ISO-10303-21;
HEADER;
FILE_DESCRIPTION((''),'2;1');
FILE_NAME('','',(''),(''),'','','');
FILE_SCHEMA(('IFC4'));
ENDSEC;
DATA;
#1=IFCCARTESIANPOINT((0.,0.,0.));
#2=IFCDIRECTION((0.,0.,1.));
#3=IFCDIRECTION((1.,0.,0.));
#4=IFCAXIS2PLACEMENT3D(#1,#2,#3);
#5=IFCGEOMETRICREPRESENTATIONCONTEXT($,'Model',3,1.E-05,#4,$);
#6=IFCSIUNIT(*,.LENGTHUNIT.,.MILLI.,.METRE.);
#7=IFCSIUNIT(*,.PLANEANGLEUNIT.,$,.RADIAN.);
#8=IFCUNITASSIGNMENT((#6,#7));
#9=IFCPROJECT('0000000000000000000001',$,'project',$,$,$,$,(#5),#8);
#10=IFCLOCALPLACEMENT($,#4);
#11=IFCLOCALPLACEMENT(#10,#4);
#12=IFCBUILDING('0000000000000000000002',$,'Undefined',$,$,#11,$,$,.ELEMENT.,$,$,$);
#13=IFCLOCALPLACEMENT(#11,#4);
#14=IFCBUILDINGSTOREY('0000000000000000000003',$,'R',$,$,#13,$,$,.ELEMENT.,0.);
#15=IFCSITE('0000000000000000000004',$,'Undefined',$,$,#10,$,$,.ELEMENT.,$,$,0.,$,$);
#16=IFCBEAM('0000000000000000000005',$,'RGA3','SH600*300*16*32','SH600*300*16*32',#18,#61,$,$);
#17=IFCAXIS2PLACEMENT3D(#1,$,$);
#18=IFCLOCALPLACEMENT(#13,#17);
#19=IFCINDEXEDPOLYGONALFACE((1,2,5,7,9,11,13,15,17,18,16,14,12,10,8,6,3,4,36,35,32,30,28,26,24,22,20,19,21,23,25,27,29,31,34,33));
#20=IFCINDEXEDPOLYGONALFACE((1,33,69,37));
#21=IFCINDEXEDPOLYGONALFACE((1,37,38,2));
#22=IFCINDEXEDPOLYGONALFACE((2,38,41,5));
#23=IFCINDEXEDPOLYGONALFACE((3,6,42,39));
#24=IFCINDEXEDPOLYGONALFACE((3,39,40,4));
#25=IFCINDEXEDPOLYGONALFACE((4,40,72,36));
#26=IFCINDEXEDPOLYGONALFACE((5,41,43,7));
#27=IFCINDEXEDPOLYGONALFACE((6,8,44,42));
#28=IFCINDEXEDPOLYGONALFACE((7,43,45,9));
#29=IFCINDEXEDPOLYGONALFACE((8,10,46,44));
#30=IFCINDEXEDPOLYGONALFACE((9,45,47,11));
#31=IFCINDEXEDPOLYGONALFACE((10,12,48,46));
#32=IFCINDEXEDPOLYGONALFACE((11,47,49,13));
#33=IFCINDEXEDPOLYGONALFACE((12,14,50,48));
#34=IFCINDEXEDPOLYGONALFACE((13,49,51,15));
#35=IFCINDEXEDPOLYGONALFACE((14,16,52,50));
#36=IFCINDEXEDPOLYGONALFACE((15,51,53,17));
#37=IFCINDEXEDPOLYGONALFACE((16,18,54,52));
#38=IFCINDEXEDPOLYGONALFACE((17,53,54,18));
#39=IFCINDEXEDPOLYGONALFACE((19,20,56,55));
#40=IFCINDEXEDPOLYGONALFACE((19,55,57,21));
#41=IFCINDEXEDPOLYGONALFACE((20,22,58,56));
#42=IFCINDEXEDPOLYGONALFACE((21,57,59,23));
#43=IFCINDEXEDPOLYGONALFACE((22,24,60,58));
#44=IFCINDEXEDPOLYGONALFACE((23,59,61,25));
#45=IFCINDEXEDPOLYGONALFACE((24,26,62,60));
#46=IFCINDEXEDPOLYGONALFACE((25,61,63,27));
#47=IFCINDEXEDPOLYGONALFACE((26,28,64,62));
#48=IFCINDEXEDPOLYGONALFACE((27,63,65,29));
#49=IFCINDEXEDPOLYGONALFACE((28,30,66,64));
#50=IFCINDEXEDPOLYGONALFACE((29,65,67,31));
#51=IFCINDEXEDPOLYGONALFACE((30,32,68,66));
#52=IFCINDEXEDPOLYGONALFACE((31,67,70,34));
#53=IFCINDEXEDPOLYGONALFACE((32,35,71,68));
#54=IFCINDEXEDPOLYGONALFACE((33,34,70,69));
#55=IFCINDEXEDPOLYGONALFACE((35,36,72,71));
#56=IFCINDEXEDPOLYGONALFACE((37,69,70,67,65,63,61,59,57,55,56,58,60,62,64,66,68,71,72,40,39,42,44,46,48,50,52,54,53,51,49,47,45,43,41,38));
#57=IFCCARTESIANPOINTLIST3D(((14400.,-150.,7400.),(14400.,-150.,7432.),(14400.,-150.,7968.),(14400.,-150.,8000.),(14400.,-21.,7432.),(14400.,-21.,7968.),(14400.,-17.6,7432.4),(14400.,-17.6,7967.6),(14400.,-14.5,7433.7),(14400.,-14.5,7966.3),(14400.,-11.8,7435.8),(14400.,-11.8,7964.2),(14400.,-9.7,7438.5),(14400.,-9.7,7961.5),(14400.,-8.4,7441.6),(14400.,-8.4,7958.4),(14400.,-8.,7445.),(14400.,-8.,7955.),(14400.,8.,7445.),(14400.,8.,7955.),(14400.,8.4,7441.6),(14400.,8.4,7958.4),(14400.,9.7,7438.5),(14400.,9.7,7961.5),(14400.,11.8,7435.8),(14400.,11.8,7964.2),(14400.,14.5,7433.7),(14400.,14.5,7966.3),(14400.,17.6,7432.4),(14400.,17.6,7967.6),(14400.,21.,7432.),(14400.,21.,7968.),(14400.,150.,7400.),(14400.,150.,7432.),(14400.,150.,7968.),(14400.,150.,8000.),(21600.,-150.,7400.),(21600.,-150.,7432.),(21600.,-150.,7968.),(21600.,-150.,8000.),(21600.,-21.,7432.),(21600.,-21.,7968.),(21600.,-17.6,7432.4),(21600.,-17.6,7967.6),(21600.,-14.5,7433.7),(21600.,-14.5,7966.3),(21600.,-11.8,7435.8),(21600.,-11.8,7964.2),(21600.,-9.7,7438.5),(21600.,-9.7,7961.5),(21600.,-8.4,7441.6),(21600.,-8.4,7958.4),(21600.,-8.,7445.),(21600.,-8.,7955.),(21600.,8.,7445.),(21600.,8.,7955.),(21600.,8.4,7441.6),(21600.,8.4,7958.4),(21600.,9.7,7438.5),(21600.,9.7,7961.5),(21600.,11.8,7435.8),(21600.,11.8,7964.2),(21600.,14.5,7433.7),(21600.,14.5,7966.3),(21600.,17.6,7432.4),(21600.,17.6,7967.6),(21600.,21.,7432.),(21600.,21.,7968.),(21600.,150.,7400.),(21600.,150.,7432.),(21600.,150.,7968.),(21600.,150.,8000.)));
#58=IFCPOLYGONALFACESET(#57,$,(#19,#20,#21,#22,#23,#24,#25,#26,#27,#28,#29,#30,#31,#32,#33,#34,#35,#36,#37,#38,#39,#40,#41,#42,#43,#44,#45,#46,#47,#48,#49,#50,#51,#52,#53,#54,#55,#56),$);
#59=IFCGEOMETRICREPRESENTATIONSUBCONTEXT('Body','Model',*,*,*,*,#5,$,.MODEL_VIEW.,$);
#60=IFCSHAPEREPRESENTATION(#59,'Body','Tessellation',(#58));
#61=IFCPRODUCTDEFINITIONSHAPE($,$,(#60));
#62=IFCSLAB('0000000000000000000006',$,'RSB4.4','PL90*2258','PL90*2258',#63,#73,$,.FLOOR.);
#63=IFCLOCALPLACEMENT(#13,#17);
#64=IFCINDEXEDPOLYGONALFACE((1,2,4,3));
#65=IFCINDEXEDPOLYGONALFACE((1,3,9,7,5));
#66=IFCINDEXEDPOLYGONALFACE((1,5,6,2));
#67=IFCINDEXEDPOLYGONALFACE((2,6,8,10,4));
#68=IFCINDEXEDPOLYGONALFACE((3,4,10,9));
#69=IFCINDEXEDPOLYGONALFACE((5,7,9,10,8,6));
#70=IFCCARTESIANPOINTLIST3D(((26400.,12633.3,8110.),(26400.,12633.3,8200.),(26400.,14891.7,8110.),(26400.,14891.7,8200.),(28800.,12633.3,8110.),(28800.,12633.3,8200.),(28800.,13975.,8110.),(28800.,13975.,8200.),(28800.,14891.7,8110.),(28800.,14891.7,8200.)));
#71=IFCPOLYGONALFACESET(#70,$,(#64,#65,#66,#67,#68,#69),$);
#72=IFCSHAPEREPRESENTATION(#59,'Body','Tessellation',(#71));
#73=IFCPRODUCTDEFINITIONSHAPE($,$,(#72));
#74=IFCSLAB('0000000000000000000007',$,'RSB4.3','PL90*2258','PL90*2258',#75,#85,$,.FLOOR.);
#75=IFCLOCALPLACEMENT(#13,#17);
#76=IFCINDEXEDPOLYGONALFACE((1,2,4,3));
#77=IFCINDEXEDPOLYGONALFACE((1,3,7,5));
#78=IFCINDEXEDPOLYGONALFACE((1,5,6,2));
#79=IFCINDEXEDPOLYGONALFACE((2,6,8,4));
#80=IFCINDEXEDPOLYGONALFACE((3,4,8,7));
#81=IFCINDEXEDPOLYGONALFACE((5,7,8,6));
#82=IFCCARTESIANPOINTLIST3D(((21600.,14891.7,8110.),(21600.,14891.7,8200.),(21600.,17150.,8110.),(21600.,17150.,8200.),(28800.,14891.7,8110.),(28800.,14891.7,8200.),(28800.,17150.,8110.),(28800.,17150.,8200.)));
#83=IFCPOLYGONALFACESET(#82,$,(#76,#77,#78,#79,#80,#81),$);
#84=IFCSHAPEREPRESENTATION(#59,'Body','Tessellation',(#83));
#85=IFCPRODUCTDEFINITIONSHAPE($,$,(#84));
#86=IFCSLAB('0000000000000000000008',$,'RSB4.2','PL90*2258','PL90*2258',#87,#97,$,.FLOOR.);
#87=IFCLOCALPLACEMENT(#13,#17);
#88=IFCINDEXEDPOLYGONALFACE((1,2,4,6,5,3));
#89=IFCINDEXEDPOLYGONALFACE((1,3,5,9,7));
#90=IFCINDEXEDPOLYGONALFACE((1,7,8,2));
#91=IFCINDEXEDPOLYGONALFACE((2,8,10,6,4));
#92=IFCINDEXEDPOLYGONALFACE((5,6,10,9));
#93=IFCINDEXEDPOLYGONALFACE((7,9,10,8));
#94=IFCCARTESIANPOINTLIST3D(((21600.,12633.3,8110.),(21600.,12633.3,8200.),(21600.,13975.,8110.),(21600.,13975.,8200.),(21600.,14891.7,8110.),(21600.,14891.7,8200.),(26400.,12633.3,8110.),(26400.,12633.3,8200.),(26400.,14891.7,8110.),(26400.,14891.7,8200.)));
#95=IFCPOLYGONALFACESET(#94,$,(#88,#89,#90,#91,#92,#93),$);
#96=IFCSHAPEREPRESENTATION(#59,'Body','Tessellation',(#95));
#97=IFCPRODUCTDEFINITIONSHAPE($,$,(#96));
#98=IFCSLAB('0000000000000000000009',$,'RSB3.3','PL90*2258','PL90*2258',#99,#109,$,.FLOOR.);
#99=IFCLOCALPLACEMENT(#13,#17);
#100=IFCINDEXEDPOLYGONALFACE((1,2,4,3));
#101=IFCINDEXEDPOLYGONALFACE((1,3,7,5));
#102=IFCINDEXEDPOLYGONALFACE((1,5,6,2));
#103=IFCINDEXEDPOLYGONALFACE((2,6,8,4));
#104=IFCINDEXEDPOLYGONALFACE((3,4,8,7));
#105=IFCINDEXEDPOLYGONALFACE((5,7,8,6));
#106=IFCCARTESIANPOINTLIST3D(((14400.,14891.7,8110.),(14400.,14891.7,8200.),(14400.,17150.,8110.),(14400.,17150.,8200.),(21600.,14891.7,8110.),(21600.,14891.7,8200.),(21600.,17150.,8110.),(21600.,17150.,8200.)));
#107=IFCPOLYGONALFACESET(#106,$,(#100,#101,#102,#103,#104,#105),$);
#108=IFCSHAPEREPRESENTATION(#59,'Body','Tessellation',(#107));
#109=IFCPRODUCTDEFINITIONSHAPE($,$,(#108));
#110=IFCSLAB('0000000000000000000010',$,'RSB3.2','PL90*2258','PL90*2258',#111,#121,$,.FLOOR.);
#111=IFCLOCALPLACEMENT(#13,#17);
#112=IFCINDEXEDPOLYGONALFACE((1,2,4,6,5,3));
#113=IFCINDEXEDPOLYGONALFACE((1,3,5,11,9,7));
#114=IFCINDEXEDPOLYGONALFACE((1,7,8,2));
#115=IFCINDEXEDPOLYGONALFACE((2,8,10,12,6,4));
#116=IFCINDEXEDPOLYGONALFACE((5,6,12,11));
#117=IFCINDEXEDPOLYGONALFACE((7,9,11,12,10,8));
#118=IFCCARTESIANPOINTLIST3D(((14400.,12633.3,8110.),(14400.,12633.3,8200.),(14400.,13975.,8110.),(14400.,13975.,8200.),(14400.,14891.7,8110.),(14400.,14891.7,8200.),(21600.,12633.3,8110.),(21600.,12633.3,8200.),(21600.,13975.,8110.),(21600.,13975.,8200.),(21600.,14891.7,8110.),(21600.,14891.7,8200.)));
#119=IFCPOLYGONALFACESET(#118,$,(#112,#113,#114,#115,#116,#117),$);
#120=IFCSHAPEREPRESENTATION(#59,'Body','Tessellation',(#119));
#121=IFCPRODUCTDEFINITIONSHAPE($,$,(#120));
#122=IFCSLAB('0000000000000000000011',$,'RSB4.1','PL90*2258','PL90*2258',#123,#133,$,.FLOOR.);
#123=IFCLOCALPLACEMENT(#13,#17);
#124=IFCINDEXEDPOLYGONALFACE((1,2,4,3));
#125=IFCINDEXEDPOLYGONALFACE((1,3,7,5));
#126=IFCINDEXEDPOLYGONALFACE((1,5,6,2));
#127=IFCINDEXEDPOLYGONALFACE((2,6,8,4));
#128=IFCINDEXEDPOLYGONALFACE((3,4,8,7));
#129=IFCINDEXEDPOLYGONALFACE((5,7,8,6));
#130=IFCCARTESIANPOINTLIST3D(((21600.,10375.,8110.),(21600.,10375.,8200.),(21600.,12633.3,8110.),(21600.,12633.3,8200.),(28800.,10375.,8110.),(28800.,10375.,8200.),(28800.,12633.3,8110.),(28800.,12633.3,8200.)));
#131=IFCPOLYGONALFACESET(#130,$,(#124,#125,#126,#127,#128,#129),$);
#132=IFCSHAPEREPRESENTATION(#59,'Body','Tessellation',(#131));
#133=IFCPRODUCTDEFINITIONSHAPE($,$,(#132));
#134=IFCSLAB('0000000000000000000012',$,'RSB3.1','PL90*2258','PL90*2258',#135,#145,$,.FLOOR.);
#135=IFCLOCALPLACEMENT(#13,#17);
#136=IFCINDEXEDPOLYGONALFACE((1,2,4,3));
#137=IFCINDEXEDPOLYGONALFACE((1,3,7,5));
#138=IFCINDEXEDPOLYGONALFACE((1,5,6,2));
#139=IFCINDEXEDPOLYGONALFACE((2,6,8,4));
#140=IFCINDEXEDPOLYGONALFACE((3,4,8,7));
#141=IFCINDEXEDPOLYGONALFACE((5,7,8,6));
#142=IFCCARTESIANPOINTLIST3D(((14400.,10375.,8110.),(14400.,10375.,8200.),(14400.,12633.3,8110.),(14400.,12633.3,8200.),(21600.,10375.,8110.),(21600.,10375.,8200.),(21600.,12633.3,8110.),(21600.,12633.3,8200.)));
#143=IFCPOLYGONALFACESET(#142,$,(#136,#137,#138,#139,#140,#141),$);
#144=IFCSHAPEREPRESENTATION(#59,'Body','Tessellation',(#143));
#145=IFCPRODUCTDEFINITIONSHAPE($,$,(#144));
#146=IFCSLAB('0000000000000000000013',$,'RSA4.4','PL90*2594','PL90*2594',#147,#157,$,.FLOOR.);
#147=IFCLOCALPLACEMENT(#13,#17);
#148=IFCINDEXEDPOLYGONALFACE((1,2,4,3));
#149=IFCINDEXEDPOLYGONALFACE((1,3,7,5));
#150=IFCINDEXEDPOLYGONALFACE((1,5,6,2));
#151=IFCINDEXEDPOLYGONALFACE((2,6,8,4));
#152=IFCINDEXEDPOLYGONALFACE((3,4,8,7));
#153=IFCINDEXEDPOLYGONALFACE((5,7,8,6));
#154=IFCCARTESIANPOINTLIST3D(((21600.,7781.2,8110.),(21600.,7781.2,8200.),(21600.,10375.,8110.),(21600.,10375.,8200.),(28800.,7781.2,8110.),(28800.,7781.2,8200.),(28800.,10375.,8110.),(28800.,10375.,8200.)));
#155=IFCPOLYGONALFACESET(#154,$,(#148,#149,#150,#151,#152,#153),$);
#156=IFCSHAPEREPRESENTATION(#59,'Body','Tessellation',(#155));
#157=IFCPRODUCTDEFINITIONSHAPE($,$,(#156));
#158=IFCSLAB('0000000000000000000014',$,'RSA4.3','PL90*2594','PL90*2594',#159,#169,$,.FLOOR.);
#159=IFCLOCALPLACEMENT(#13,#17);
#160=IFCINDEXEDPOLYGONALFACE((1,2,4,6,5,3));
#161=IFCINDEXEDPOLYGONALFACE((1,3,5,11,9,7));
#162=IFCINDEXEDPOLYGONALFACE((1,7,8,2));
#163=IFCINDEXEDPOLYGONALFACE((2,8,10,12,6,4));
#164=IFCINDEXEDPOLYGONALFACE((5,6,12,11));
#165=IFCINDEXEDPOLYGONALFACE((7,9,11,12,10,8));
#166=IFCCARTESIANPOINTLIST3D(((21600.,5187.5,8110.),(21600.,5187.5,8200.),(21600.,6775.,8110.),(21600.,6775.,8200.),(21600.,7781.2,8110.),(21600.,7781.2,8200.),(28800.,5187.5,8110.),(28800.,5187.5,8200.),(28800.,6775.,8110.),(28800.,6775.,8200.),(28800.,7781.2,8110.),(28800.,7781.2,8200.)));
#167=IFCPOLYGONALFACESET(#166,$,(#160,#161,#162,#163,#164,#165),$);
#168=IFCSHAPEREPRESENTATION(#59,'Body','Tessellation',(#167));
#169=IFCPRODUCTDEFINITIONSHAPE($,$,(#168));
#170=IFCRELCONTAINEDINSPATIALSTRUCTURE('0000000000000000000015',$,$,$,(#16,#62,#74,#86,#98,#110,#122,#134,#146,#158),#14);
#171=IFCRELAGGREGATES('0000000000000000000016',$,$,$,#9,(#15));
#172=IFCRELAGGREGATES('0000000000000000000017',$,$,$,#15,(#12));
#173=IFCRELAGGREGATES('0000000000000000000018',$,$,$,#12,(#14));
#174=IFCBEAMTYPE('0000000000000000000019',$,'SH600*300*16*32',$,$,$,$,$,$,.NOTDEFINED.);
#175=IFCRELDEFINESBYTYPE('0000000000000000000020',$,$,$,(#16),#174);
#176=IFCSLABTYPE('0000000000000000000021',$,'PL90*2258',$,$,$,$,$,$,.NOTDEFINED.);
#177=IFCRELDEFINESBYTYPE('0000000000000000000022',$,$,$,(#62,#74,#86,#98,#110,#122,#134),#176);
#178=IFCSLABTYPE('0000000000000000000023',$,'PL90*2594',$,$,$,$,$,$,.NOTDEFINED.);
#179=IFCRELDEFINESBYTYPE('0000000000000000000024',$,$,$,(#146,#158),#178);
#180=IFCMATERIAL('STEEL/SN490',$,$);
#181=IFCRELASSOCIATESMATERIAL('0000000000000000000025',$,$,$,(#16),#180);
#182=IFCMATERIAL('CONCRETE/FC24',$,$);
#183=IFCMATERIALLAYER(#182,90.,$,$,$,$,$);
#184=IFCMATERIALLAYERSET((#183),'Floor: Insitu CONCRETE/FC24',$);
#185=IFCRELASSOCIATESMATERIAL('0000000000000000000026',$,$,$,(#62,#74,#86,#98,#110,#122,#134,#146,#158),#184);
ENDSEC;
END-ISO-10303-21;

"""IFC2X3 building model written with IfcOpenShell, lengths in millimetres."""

from ifc_helpers import new_model, si_unit, frame, origin_with_axes, origin_2d_with_axis, place, context, subcontext, project, spatial, polyline, i_section, outline, extrude, material, layer, layer_set, layer_usage, type_object, element, save


model = new_model("IFC2X3")

# Units and contexts
model_context = context("Model", 3, precision=1e-05, world=origin_with_axes())
body_context = subcontext(model_context, "Body", "Model", "MODEL_VIEW")
ifc_project = project(units=[si_unit("LENGTHUNIT", "METRE", prefix="MILLI"), si_unit("PLANEANGLEUNIT", "RADIAN")], contexts=[model_context])

# Site, building, storey
site_placement = place(None, origin_with_axes())
site = spatial("IfcSite", under=ifc_project, at=site_placement, Name="Undefined", CompositionType="ELEMENT", RefElevation=0.0)
building_placement = place(site_placement, origin_with_axes())
building = spatial("IfcBuilding", under=site, at=building_placement, Name="Undefined", CompositionType="ELEMENT")
storey_placement = place(building_placement, origin_with_axes())
storey = spatial("IfcBuildingStorey", under=building, at=storey_placement, Name="R", CompositionType="ELEMENT", Elevation=0.0)

# Beam
ifc_material_1 = material(Name="STEEL/SN490")
beam_type_1 = type_object("IfcBeamType", Name="SH600*300*16*32", PredefinedType="NOTDEFINED")
for number, where, z_axis, x_axis, name in (
    (1, (14400.0, 0.0, 7700.0), (0.0, 0.0, 1.0), (1.0, 0.0, 0.0), "RGA3"),
):
    element("IfcBeam", number, at=place(storey_placement, frame(where, z_axis=z_axis, x_axis=x_axis)), inside=storey, type_object=beam_type_1, material=ifc_material_1, Name=name, Description="SH600*300*16*32", ObjectType="SH600*300*16*32", context=body_context, shape_type="SweptSolid", body=[
        extrude(i_section(OverallWidth=300.0, OverallDepth=600.0, WebThickness=16.0, FlangeThickness=32.0, FilletRadius=13.0, at=origin_2d_with_axis()), frame((7200.0, 0.0, 0.0), z_axis=(-1.0, 0.0, 0.0), x_axis=(0.0, -1.0, 0.0)), (0.0, 0.0, 1.0), 7200.0),
    ])

# Slabs
ifc_material_2 = material(Name="CONCRETE/FC24")
ifc_layer = layer(ifc_material_2, 90.0)
ifc_layer_set = layer_set([ifc_layer], Name="Floor: Insitu CONCRETE/FC24")
ifc_layer_usage_1 = layer_usage(ifc_layer_set, "AXIS3", "POSITIVE", -45.0)
slab_type_1 = type_object("IfcSlabType", Name="PL90*2258", PredefinedType="NOTDEFINED")
slab_1_placement = place(storey_placement, frame((26400.0, 12633.3, 8155.0), z_axis=(0.0, 0.0, 1.0), x_axis=(1.0, 0.0, 0.0)))
element("IfcSlab", 2, at=slab_1_placement, inside=storey, type_object=slab_type_1, material=ifc_layer_usage_1, Name="RSB4.4", Description="PL90*2258", ObjectType="PL90*2258", PredefinedType="FLOOR", context=body_context, shape_type="SweptSolid", body=[
    extrude(outline(polyline([(0.0, 0.0), (2400.0, 0.0), (2400.0, 1341.7), (2400.0, 2258.4), (0.0, 2258.4), (0.0, 0.0)])), frame((0.0, 0.0, -45.0), z_axis=(0.0, 0.0, 1.0), x_axis=(1.0, 0.0, 0.0)), (0.0, 0.0, 1.0), 90.0),
])
ifc_layer_usage_2 = layer_usage(ifc_layer_set, "AXIS3", "POSITIVE", -45.0)
slab_2_placement = place(storey_placement, frame((21600.0, 14891.7, 8155.0), z_axis=(0.0, 0.0, 1.0), x_axis=(1.0, 0.0, 0.0)))
element("IfcSlab", 3, at=slab_2_placement, inside=storey, type_object=slab_type_1, material=ifc_layer_usage_2, Name="RSB4.3", Description="PL90*2258", ObjectType="PL90*2258", PredefinedType="FLOOR", context=body_context, shape_type="SweptSolid", body=[
    extrude(outline(polyline([(0.0, 0.0), (7200.0, 0.0), (7200.0, 2258.3), (0.0, 2258.3), (0.0, 0.0)])), frame((0.0, 0.0, -45.0), z_axis=(0.0, 0.0, 1.0), x_axis=(1.0, 0.0, 0.0)), (0.0, 0.0, 1.0), 90.0),
])
ifc_layer_usage_3 = layer_usage(ifc_layer_set, "AXIS3", "POSITIVE", -45.0)
slab_3_placement = place(storey_placement, frame((21600.0, 12633.3, 8155.0), z_axis=(0.0, 0.0, 1.0), x_axis=(1.0, 0.0, 0.0)))
element("IfcSlab", 4, at=slab_3_placement, inside=storey, type_object=slab_type_1, material=ifc_layer_usage_3, Name="RSB4.2", Description="PL90*2258", ObjectType="PL90*2258", PredefinedType="FLOOR", context=body_context, shape_type="SweptSolid", body=[
    extrude(outline(polyline([(0.0, 0.0), (4800.0, 0.0), (4800.0, 2258.4), (0.0, 2258.4), (0.0, 1341.7), (0.0, 0.0)])), frame((0.0, 0.0, -45.0), z_axis=(0.0, 0.0, 1.0), x_axis=(1.0, 0.0, 0.0)), (0.0, 0.0, 1.0), 90.0),
])
ifc_layer_usage_4 = layer_usage(ifc_layer_set, "AXIS3", "POSITIVE", -45.0)
slab_4_placement = place(storey_placement, frame((14400.0, 14891.7, 8155.0), z_axis=(0.0, 0.0, 1.0), x_axis=(1.0, 0.0, 0.0)))
element("IfcSlab", 5, at=slab_4_placement, inside=storey, type_object=slab_type_1, material=ifc_layer_usage_4, Name="RSB3.3", Description="PL90*2258", ObjectType="PL90*2258", PredefinedType="FLOOR", context=body_context, shape_type="SweptSolid", body=[
    extrude(outline(polyline([(0.0, 0.0), (7200.0, 0.0), (7200.0, 2258.3), (0.0, 2258.3), (0.0, 0.0)])), frame((0.0, 0.0, -45.0), z_axis=(0.0, 0.0, 1.0), x_axis=(1.0, 0.0, 0.0)), (0.0, 0.0, 1.0), 90.0),
])
ifc_layer_usage_5 = layer_usage(ifc_layer_set, "AXIS3", "POSITIVE", -45.0)
slab_5_placement = place(storey_placement, frame((14400.0, 12633.3, 8155.0), z_axis=(0.0, 0.0, 1.0), x_axis=(1.0, 0.0, 0.0)))
element("IfcSlab", 6, at=slab_5_placement, inside=storey, type_object=slab_type_1, material=ifc_layer_usage_5, Name="RSB3.2", Description="PL90*2258", ObjectType="PL90*2258", PredefinedType="FLOOR", context=body_context, shape_type="SweptSolid", body=[
    extrude(outline(polyline([(0.0, 0.0), (7200.0, 0.0), (7200.0, 1341.7), (7200.0, 2258.4), (0.0, 2258.4), (0.0, 1341.7), (0.0, 0.0)])), frame((0.0, 0.0, -45.0), z_axis=(0.0, 0.0, 1.0), x_axis=(1.0, 0.0, 0.0)), (0.0, 0.0, 1.0), 90.0),
])
ifc_layer_usage_6 = layer_usage(ifc_layer_set, "AXIS3", "POSITIVE", -45.0)
slab_6_placement = place(storey_placement, frame((21600.0, 10375.0, 8155.0), z_axis=(0.0, 0.0, 1.0), x_axis=(1.0, 0.0, 0.0)))
element("IfcSlab", 7, at=slab_6_placement, inside=storey, type_object=slab_type_1, material=ifc_layer_usage_6, Name="RSB4.1", Description="PL90*2258", ObjectType="PL90*2258", PredefinedType="FLOOR", context=body_context, shape_type="SweptSolid", body=[
    extrude(outline(polyline([(0.0, 0.0), (7200.0, 0.0), (7200.0, 2258.3), (0.0, 2258.3), (0.0, 0.0)])), frame((0.0, 0.0, -45.0), z_axis=(0.0, 0.0, 1.0), x_axis=(1.0, 0.0, 0.0)), (0.0, 0.0, 1.0), 90.0),
])
ifc_layer_usage_7 = layer_usage(ifc_layer_set, "AXIS3", "POSITIVE", -45.0)
slab_7_placement = place(storey_placement, frame((14400.0, 10375.0, 8155.0), z_axis=(0.0, 0.0, 1.0), x_axis=(1.0, 0.0, 0.0)))
element("IfcSlab", 8, at=slab_7_placement, inside=storey, type_object=slab_type_1, material=ifc_layer_usage_7, Name="RSB3.1", Description="PL90*2258", ObjectType="PL90*2258", PredefinedType="FLOOR", context=body_context, shape_type="SweptSolid", body=[
    extrude(outline(polyline([(0.0, 0.0), (7200.0, 0.0), (7200.0, 2258.3), (0.0, 2258.3), (0.0, 0.0)])), frame((0.0, 0.0, -45.0), z_axis=(0.0, 0.0, 1.0), x_axis=(1.0, 0.0, 0.0)), (0.0, 0.0, 1.0), 90.0),
])
ifc_layer_usage_8 = layer_usage(ifc_layer_set, "AXIS3", "POSITIVE", -45.0)
slab_type_2 = type_object("IfcSlabType", Name="PL90*2594", PredefinedType="NOTDEFINED")
slab_8_placement = place(storey_placement, frame((21600.0, 7781.2, 8155.0), z_axis=(0.0, 0.0, 1.0), x_axis=(1.0, 0.0, 0.0)))
element("IfcSlab", 9, at=slab_8_placement, inside=storey, type_object=slab_type_2, material=ifc_layer_usage_8, Name="RSA4.4", Description="PL90*2594", ObjectType="PL90*2594", PredefinedType="FLOOR", context=body_context, shape_type="SweptSolid", body=[
    extrude(outline(polyline([(0.0, 0.0), (7200.0, 0.0), (7200.0, 2593.8), (0.0, 2593.8), (0.0, 0.0)])), frame((0.0, 0.0, -45.0), z_axis=(0.0, 0.0, 1.0), x_axis=(1.0, 0.0, 0.0)), (0.0, 0.0, 1.0), 90.0),
])
ifc_layer_usage_9 = layer_usage(ifc_layer_set, "AXIS3", "POSITIVE", -45.0)
slab_9_placement = place(storey_placement, frame((21600.0, 5187.5, 8155.0), z_axis=(0.0, 0.0, 1.0), x_axis=(1.0, 0.0, 0.0)))
element("IfcSlab", 10, at=slab_9_placement, inside=storey, type_object=slab_type_2, material=ifc_layer_usage_9, Name="RSA4.3", Description="PL90*2594", ObjectType="PL90*2594", PredefinedType="FLOOR", context=body_context, shape_type="SweptSolid", body=[
    extrude(outline(polyline([(0.0, 0.0), (7200.0, 0.0), (7200.0, 1587.5), (7200.0, 2593.8), (0.0, 2593.8), (0.0, 1587.5), (0.0, 0.0)])), frame((0.0, 0.0, -45.0), z_axis=(0.0, 0.0, 1.0), x_axis=(1.0, 0.0, 0.0)), (0.0, 0.0, 1.0), 90.0),
])

save(model, "model.ifc")
